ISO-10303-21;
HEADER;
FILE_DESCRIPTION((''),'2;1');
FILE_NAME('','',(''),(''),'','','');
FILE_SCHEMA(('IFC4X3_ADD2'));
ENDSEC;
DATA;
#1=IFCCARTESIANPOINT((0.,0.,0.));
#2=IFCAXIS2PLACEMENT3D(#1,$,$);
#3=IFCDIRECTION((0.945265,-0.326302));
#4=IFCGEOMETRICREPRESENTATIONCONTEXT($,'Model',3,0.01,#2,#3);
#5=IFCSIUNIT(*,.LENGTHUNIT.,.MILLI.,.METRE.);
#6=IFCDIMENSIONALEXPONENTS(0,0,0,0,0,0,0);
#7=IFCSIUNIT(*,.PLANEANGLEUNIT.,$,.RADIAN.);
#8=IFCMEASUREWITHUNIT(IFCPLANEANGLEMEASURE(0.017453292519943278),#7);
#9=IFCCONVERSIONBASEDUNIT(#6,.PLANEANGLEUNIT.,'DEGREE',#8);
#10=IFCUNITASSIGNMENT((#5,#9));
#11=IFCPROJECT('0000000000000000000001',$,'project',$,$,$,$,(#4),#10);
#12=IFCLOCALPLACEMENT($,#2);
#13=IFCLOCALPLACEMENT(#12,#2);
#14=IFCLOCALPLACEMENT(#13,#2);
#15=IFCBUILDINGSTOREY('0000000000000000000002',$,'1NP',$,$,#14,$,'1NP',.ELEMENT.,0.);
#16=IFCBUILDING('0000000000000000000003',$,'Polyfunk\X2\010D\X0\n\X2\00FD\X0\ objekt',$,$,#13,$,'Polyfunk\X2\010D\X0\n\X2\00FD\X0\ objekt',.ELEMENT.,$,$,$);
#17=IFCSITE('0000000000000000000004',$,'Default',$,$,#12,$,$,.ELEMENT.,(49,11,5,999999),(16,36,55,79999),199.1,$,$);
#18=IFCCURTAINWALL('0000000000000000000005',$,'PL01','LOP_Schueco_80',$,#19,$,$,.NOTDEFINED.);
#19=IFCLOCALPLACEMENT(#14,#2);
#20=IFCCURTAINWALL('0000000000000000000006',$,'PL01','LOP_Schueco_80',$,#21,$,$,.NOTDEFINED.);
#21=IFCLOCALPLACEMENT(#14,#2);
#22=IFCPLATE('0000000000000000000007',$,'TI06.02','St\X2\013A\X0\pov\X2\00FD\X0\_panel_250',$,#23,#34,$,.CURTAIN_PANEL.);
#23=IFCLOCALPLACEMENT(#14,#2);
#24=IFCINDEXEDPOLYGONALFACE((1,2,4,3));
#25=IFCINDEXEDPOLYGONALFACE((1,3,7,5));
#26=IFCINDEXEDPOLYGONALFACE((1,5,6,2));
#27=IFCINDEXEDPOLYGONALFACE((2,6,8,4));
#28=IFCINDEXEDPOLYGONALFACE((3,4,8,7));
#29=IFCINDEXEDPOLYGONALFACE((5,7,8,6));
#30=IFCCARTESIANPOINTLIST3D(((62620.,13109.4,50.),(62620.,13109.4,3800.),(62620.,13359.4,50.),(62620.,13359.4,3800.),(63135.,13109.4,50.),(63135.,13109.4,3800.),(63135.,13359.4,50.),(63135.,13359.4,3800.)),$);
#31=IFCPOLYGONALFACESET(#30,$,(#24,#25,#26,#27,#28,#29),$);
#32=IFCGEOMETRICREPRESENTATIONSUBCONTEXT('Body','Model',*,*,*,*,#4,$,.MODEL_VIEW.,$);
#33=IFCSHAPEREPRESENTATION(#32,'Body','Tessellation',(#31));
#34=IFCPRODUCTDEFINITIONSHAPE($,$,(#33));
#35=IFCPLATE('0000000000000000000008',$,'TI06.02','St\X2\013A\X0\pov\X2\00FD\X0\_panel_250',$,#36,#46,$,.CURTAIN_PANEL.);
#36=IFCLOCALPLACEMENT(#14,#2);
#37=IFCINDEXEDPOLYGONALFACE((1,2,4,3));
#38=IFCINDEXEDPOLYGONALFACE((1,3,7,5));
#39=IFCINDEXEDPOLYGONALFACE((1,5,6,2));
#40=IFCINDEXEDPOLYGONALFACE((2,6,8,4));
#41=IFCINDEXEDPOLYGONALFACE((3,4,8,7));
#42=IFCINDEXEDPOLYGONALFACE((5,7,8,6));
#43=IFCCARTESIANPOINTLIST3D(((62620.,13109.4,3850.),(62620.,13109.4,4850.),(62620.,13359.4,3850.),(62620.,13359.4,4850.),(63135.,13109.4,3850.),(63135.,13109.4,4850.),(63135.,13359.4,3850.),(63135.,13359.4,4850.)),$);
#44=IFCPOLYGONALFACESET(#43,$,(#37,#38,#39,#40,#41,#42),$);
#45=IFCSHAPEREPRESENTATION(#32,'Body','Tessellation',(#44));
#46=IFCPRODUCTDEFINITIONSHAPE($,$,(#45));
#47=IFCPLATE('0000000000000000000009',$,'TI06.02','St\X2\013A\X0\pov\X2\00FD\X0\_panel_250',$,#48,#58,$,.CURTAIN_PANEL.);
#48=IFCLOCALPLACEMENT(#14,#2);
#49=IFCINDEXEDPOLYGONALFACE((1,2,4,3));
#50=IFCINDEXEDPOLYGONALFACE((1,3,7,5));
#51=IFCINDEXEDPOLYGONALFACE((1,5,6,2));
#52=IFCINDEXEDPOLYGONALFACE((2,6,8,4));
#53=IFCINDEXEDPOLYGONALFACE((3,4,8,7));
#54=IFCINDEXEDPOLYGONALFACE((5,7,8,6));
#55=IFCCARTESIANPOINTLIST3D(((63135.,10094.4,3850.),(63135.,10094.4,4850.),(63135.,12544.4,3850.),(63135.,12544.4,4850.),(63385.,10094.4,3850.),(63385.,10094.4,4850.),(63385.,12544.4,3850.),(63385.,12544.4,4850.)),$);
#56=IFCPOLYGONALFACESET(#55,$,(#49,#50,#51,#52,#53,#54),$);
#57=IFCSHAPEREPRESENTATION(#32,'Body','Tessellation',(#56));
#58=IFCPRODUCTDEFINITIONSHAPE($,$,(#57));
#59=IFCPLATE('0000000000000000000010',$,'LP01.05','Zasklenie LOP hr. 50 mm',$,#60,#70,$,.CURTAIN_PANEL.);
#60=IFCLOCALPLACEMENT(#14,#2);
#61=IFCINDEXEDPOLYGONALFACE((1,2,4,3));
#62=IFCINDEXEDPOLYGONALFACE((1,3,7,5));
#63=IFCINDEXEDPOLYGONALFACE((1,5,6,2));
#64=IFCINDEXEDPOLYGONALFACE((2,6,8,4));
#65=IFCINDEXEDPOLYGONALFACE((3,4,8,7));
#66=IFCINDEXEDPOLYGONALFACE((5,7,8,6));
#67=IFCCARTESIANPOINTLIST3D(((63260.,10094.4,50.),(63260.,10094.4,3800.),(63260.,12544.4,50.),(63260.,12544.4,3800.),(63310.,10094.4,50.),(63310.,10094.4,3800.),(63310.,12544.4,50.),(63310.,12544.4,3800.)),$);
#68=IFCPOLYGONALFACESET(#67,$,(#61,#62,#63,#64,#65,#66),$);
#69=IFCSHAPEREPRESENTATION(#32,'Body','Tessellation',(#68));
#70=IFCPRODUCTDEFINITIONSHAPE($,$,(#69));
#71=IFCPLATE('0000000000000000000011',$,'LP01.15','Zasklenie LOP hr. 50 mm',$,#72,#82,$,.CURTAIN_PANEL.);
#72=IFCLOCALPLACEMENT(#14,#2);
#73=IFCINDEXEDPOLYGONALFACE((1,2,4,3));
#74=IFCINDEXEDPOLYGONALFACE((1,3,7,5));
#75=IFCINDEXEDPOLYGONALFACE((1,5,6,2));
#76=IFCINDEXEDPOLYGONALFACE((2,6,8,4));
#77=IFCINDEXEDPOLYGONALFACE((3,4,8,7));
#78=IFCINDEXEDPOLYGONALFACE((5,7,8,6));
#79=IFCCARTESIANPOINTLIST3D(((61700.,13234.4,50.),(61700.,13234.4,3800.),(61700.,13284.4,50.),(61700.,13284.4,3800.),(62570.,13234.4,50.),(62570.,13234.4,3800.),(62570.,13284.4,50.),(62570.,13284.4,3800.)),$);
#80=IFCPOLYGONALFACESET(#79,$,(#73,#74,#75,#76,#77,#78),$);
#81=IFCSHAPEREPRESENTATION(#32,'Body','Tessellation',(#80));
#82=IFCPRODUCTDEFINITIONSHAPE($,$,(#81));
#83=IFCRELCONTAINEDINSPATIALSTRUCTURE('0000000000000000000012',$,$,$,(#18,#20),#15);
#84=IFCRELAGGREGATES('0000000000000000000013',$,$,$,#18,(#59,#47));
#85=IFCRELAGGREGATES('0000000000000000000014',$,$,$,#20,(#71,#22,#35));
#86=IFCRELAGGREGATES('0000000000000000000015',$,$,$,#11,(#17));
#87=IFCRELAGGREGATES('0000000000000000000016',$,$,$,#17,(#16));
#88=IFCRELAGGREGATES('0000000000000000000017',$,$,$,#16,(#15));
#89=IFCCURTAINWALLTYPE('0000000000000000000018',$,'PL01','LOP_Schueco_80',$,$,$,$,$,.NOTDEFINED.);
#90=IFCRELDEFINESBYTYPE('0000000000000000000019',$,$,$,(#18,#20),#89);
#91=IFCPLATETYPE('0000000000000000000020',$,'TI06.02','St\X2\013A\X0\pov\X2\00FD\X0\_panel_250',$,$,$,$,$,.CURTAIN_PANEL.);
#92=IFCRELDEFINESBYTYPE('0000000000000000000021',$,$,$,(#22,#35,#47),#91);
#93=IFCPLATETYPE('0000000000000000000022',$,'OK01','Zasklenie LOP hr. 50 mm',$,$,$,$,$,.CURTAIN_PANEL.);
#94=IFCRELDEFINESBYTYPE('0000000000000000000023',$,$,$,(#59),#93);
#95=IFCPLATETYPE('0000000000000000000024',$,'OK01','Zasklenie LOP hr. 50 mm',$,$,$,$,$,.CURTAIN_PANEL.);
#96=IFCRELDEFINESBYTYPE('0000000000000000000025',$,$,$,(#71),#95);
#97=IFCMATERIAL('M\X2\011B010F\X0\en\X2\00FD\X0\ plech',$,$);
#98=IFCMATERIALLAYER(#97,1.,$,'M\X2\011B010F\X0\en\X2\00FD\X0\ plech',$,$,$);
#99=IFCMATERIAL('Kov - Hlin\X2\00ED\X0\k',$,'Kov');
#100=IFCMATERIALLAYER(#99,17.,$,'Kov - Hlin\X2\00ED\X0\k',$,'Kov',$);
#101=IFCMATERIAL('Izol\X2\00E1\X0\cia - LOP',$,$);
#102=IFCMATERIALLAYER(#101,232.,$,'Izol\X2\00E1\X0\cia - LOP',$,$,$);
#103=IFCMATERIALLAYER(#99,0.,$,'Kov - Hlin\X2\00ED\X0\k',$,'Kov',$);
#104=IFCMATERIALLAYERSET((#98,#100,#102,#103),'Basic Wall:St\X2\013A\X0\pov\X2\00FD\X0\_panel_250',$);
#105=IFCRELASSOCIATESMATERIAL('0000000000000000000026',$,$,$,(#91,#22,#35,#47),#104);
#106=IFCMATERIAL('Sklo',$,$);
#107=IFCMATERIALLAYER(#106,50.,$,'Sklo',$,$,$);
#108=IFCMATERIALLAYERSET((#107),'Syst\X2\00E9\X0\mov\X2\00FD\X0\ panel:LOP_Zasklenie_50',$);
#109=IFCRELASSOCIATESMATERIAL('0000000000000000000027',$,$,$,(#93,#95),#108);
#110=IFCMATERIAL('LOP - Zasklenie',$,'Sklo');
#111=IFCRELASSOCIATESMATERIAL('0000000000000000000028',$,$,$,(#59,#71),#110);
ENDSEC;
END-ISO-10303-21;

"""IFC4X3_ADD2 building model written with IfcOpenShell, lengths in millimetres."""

from ifc_helpers import new_model, entity, si_unit, converted_unit, direction, frame, frame_2d, origin, place, context, subcontext, project, spatial, rectangle, extrude, source, transform, mapped, material, layer, layer_set, layer_usage, type_object, type_shapes, element, aggregate, save


model = new_model("IFC4X3_ADD2")

# Units and contexts
model_context = context("Model", 3, precision=0.01, world=origin(), true_north=direction((0.945265, -0.326302)))
body_context = subcontext(model_context, "Body", "Model", "MODEL_VIEW")
ifc_project = project(units=[si_unit("LENGTHUNIT", "METRE", prefix="MILLI"), converted_unit("PLANEANGLEUNIT", "DEGREE", entity("IfcPlaneAngleMeasure", 0.017453292519943278), si_unit("PLANEANGLEUNIT", "RADIAN"), dimensions=[0, 0, 0, 0, 0, 0, 0])], contexts=[model_context])

# Site, building, storey
site_placement = place(None, origin())
site = spatial("IfcSite", under=ifc_project, at=site_placement, Name="Default", CompositionType="ELEMENT", RefLatitude=(49, 11, 5, 999999), RefLongitude=(16, 36, 55, 79999), RefElevation=199.1)
building_placement = place(site_placement, origin())
building = spatial("IfcBuilding", under=site, at=building_placement, Name="Polyfunkčný objekt", LongName="Polyfunkčný objekt", CompositionType="ELEMENT")
storey_placement = place(building_placement, origin())
storey = spatial("IfcBuildingStorey", under=building, at=storey_placement, Name="1NP", LongName="1NP", CompositionType="ELEMENT", Elevation=0.0)

# Curtain walls
curtain_wall_type = type_object("IfcCurtainWallType", Name="PL01", Description="LOP_Schueco_80", PredefinedType="NOTDEFINED")
curtain_wall_1_placement = place(storey_placement, origin())
curtain_wall_1 = element("IfcCurtainWall", 1, at=curtain_wall_1_placement, inside=storey, type_object=curtain_wall_type, Name="PL01", Description="LOP_Schueco_80", PredefinedType="NOTDEFINED")
curtain_wall_2_placement = place(storey_placement, origin())
curtain_wall_2 = element("IfcCurtainWall", 2, at=curtain_wall_2_placement, inside=storey, type_object=curtain_wall_type, Name="PL01", Description="LOP_Schueco_80", PredefinedType="NOTDEFINED")

# Plates
ifc_material_1 = material(Name="Měďený plech")
ifc_layer_1 = layer(ifc_material_1, 1.0, Name="Měďený plech")
ifc_material_2 = material(Name="Kov - Hliník", Category="Kov")
ifc_layer_2 = layer(ifc_material_2, 17.0, Name="Kov - Hliník", Category="Kov")
ifc_material_3 = material(Name="Izolácia - LOP")
ifc_layer_3 = layer(ifc_material_3, 232.0, Name="Izolácia - LOP")
ifc_layer_4 = layer(ifc_material_2, 0.0, Name="Kov - Hliník", Category="Kov")
ifc_layer_set_1 = layer_set([ifc_layer_1, ifc_layer_2, ifc_layer_3, ifc_layer_4], Name="Basic Wall:Stĺpový_panel_250")
ifc_layer_usage_1 = layer_usage(ifc_layer_set_1, "AXIS2", "NEGATIVE", 125.0)
plate_type_1 = type_object("IfcPlateType", Name="TI06.02", Description="Stĺpový_panel_250", PredefinedType="CURTAIN_PANEL", material=ifc_layer_set_1)
plate_1_placement = place(storey_placement, frame((62620.0, 13234.4, 50.0)))
plate_1 = element("IfcPlate", 3, at=plate_1_placement, type_object=plate_type_1, material=ifc_layer_usage_1, Name="TI06.02", Description="Stĺpový_panel_250", PredefinedType="CURTAIN_PANEL", context=body_context, shape_type="SweptSolid", body=[
    extrude(rectangle(XDim=250.0, YDim=515.0, at=frame_2d((0.0, 0.0), x_axis=(1.0, 0.0))), frame((257.5, 0.0, 0.0), z_axis=(0.0, 0.0, 1.0), x_axis=(0.0, 1.0, 0.0)), (0.0, 0.0, 1.0), 3750.0),
])
ifc_layer_usage_2 = layer_usage(ifc_layer_set_1, "AXIS2", "NEGATIVE", 125.0)
plate_2_placement = place(storey_placement, frame((62620.0, 13234.4, 3850.0)))
plate_2 = element("IfcPlate", 4, at=plate_2_placement, type_object=plate_type_1, material=ifc_layer_usage_2, Name="TI06.02", Description="Stĺpový_panel_250", PredefinedType="CURTAIN_PANEL", context=body_context, shape_type="SweptSolid", body=[
    extrude(rectangle(XDim=250.0, YDim=515.0, at=frame_2d((0.0, 0.0), x_axis=(1.0, 0.0))), frame((257.5, 0.0, 0.0), z_axis=(0.0, 0.0, 1.0), x_axis=(0.0, 1.0, 0.0)), (0.0, 0.0, 1.0), 1000.0),
])
ifc_layer_usage_3 = layer_usage(ifc_layer_set_1, "AXIS2", "NEGATIVE", 125.0)
plate_3_placement = place(storey_placement, frame((63260.0, 12544.4, 3850.0), z_axis=(0.0, 0.0, 1.0), x_axis=(0.0, -1.0, 0.0)))
plate_3 = element("IfcPlate", 5, at=plate_3_placement, type_object=plate_type_1, material=ifc_layer_usage_3, Name="TI06.02", Description="Stĺpový_panel_250", PredefinedType="CURTAIN_PANEL", context=body_context, shape_type="SweptSolid", body=[
    extrude(rectangle(XDim=250.0, YDim=2450.0, at=frame_2d((0.0, 0.0), x_axis=(1.0, 0.0))), frame((1225.0, 0.0, 0.0), z_axis=(0.0, 0.0, 1.0), x_axis=(0.0, 1.0, 0.0)), (0.0, 0.0, 1.0), 1000.0),
])
ifc_material_4 = material(Name="LOP - Zasklenie", Category="Sklo")
ifc_material_5 = material(Name="Sklo")
ifc_layer_5 = layer(ifc_material_5, 50.0, Name="Sklo")
ifc_layer_set_2 = layer_set([ifc_layer_5], Name="Systémový panel:LOP_Zasklenie_50")
plate_type_2 = type_object("IfcPlateType", Name="OK01", Description="Zasklenie LOP hr. 50 mm", PredefinedType="CURTAIN_PANEL", material=ifc_layer_set_2)
shared_shape_1 = source(origin(), body_context, "Body", "SweptSolid", [
    extrude(rectangle(XDim=3750.0, YDim=2450.0, at=frame_2d((-141.7, 0.0), x_axis=(1.0, 0.0))), frame((0.0, 0.0, 2016.7), z_axis=(0.0, 1.0, 0.0), x_axis=(0.0, 0.0, 1.0)), (0.0, 0.0, 1.0), 50.0),
])
type_shapes(plate_type_2, [shared_shape_1])
plate_4_placement = place(curtain_wall_1_placement, frame((63260.0, 11319.4, 50.0), z_axis=(0.0, 0.0, 1.0), x_axis=(0.0, -1.0, 0.0)))
plate_4 = element("IfcPlate", 6, at=plate_4_placement, type_object=plate_type_2, material=ifc_material_4, Name="LP01.05", Description="Zasklenie LOP hr. 50 mm", PredefinedType="CURTAIN_PANEL", context=body_context, shape_type="MappedRepresentation", body=[
    mapped(shared_shape_1, transform((0.0, 0.0, 0.0), scale=1.0)),
])
aggregate(curtain_wall_1, [plate_4, plate_3])
plate_type_3 = type_object("IfcPlateType", Name="OK01", Description="Zasklenie LOP hr. 50 mm", PredefinedType="CURTAIN_PANEL", material=ifc_layer_set_2)
shared_shape_2 = source(origin(), body_context, "Body", "SweptSolid", [
    extrude(rectangle(XDim=3750.0, YDim=870.0, at=frame_2d((-141.7, 0.0), x_axis=(1.0, 0.0))), frame((0.0, 0.0, 2016.7), z_axis=(0.0, 1.0, 0.0), x_axis=(0.0, 0.0, 1.0)), (0.0, 0.0, 1.0), 50.0),
])
type_shapes(plate_type_3, [shared_shape_2])
plate_5_placement = place(curtain_wall_2_placement, frame((62135.0, 13234.4, 50.0)))
plate_5 = element("IfcPlate", 7, at=plate_5_placement, type_object=plate_type_3, material=ifc_material_4, Name="LP01.15", Description="Zasklenie LOP hr. 50 mm", PredefinedType="CURTAIN_PANEL", context=body_context, shape_type="MappedRepresentation", body=[
    mapped(shared_shape_2, transform((0.0, 0.0, 0.0), scale=1.0)),
])
aggregate(curtain_wall_2, [plate_5, plate_1, plate_2])

save(model, "model.ifc")
